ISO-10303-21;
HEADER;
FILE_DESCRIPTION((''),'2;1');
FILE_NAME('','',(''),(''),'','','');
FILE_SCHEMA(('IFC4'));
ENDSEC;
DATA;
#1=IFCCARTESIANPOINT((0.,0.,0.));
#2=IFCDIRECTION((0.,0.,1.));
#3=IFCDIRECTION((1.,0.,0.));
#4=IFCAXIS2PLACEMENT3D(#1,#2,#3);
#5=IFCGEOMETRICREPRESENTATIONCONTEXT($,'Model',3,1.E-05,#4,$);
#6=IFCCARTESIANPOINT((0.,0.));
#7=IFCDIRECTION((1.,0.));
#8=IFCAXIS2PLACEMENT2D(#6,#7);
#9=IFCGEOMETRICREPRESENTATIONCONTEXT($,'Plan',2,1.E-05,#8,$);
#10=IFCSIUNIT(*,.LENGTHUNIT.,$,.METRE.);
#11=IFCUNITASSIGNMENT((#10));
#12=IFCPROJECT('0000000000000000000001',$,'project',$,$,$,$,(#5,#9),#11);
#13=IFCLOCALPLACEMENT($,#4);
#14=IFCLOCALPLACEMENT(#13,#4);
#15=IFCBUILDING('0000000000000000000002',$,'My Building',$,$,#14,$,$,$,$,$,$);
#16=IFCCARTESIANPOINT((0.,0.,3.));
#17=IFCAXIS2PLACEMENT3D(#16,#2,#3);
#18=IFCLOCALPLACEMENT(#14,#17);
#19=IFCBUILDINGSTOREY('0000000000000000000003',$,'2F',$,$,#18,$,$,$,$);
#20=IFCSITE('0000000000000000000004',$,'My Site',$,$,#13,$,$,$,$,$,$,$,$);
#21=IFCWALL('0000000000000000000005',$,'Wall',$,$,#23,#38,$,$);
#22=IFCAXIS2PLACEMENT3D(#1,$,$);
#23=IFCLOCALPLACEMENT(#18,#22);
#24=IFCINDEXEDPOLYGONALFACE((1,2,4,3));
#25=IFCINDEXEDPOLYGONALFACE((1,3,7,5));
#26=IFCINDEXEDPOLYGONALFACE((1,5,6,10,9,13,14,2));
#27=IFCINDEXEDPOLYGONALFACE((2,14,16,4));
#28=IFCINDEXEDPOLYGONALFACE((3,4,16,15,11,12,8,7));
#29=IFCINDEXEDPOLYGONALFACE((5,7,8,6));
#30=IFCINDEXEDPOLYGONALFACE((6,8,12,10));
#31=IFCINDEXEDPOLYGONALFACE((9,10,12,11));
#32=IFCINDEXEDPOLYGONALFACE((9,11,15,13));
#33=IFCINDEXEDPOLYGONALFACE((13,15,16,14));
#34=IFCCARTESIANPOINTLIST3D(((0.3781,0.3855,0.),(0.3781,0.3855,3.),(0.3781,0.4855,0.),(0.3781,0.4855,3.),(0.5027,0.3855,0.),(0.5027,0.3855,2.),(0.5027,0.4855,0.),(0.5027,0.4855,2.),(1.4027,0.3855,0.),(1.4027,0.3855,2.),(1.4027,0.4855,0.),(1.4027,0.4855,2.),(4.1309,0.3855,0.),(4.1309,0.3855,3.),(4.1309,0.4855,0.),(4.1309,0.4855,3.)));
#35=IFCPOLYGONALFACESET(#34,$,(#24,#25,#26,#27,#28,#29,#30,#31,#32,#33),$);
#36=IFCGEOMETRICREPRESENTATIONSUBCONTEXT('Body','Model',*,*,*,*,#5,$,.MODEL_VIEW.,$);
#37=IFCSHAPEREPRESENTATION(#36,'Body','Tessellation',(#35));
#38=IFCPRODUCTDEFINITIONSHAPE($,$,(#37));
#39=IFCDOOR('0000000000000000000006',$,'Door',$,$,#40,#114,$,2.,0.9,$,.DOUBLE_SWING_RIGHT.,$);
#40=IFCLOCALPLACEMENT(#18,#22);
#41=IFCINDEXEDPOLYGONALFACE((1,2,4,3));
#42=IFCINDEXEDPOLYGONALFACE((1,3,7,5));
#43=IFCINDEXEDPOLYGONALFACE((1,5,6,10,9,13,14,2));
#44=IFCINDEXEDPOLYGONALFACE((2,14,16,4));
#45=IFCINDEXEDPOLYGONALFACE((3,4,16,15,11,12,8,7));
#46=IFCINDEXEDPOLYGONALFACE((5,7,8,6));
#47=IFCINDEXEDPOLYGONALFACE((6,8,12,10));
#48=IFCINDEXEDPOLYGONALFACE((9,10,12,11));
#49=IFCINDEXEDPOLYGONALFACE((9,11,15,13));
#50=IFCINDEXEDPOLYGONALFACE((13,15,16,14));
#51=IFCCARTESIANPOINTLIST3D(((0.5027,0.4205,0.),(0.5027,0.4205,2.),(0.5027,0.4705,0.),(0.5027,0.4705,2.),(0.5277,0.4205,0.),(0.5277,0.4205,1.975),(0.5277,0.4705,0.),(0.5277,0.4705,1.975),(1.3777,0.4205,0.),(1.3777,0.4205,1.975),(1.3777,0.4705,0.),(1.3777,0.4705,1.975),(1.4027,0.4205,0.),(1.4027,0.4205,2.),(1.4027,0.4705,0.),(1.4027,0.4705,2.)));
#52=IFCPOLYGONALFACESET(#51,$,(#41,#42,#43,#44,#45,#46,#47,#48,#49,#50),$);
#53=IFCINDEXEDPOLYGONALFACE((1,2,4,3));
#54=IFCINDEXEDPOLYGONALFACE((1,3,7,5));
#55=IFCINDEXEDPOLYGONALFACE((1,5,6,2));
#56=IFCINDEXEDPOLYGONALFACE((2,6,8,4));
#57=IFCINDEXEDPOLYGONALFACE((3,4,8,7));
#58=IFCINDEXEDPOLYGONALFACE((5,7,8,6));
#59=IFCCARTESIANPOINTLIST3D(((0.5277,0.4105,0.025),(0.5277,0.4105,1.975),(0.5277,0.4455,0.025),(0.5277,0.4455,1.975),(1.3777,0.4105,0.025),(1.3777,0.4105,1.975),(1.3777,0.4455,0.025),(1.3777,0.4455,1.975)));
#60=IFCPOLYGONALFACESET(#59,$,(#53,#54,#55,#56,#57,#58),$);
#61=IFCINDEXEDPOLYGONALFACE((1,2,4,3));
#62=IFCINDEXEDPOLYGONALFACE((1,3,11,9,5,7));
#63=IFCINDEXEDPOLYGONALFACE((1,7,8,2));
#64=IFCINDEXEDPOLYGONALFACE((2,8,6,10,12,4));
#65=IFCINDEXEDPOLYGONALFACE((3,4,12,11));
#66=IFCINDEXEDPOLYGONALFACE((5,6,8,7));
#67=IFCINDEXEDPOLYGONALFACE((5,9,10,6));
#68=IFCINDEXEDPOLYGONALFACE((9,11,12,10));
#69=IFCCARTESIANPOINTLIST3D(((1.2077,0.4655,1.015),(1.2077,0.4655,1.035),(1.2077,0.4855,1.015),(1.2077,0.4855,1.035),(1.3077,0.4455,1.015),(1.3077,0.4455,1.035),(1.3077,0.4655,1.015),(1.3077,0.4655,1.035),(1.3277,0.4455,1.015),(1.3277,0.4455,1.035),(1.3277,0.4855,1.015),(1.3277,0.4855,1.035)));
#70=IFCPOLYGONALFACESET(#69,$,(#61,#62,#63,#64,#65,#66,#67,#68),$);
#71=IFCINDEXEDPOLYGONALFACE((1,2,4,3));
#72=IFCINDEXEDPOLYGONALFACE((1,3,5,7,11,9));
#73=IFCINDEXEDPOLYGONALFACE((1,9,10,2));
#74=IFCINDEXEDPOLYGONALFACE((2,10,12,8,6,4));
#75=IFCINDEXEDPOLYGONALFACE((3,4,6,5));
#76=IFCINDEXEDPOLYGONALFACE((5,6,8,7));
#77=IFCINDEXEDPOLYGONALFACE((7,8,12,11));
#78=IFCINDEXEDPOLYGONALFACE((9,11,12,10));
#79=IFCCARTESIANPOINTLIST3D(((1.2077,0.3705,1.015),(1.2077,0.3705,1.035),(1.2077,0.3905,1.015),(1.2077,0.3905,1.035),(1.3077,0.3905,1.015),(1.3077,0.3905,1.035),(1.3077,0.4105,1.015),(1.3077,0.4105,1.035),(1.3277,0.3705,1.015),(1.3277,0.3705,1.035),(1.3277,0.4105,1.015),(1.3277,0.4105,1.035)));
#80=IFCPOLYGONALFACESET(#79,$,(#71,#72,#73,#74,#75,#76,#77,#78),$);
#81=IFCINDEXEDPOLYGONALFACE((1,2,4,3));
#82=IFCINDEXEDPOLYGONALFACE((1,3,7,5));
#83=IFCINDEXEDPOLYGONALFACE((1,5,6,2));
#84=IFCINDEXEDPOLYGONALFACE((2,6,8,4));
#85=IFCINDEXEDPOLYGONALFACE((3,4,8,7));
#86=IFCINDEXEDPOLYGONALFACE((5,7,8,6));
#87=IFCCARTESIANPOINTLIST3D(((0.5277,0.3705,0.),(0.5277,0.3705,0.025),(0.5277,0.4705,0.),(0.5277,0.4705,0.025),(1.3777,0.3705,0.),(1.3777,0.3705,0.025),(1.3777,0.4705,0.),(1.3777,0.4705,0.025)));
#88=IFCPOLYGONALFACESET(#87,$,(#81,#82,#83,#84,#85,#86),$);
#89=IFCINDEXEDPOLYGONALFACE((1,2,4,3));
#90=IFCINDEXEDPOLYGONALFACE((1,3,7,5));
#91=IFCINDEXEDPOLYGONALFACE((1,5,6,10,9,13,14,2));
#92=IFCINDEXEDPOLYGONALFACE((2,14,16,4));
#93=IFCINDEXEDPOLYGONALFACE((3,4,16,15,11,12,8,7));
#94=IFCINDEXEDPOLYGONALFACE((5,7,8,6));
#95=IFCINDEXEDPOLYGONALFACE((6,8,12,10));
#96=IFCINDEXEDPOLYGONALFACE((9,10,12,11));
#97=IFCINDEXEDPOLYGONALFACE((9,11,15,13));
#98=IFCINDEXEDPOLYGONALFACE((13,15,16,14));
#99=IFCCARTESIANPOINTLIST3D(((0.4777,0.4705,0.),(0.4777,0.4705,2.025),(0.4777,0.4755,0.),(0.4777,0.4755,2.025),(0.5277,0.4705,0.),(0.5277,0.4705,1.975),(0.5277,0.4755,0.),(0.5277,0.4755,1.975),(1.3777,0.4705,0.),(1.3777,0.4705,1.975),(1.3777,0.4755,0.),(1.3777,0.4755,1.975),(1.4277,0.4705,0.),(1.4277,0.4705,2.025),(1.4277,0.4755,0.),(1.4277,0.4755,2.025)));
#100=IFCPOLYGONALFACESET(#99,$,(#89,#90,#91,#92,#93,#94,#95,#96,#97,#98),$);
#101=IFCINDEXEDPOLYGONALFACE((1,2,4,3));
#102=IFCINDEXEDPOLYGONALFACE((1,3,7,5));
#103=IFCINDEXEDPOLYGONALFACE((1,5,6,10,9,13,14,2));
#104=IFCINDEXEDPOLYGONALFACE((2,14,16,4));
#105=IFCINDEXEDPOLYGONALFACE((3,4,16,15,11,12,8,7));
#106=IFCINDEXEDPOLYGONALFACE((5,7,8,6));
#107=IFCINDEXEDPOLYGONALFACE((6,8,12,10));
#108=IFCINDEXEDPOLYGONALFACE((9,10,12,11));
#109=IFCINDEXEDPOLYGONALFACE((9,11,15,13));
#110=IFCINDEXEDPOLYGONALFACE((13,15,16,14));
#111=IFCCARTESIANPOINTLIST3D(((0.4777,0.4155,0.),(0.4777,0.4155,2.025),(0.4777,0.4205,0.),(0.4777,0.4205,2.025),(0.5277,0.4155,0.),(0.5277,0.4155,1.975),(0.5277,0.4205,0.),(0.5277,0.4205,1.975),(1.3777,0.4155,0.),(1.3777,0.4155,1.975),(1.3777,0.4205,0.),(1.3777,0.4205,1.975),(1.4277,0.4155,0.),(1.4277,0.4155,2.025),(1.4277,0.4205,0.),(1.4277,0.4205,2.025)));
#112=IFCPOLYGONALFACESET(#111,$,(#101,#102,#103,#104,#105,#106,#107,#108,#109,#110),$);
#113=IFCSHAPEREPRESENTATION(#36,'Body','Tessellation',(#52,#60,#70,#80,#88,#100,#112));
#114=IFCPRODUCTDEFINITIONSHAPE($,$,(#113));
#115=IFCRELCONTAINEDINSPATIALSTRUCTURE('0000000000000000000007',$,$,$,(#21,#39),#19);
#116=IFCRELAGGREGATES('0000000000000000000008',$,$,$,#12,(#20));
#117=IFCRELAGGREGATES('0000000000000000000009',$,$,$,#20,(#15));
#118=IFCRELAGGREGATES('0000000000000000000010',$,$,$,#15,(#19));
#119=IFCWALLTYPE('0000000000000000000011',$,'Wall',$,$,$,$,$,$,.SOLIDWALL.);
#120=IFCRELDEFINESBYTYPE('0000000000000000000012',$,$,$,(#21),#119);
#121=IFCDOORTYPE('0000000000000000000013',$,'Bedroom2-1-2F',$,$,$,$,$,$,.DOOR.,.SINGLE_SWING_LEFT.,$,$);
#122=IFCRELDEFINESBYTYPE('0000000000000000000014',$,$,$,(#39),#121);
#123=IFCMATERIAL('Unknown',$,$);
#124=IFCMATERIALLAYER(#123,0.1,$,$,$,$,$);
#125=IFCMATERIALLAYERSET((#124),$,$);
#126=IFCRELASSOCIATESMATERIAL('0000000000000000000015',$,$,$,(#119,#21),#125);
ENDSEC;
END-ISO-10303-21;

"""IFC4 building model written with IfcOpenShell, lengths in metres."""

from ifc_helpers import new_model, entity, si_unit, frame, origin_with_axes, origin_2d_with_axis, place, context, subcontext, project, spatial, line, indexed_curve, outline, extrude, shape, source, transform, mapped, material, layer, layer_set, layer_usage, type_object, type_shapes, element, fill, save


model = new_model("IFC4")

# Units and contexts
model_context = context("Model", 3, precision=1e-05, world=origin_with_axes())
plan_context = context("Plan", 2, precision=1e-05, world=origin_2d_with_axis())
body_context_1 = subcontext(model_context, "Body", "Model", "MODEL_VIEW")
body_context_2 = subcontext(plan_context, "Body", "Plan", "PLAN_VIEW")
ifc_project = project(units=[si_unit("LENGTHUNIT", "METRE")], contexts=[model_context, plan_context])

# Site, building, storey
site_placement = place(None, origin_with_axes())
site = spatial("IfcSite", under=ifc_project, at=site_placement, Name="My Site")
building_placement = place(site_placement, origin_with_axes())
building = spatial("IfcBuilding", under=site, at=building_placement, Name="My Building")
storey_placement = place(building_placement, frame((0.0, 0.0, 3.0), z_axis=(0.0, 0.0, 1.0), x_axis=(1.0, 0.0, 0.0)))
storey = spatial("IfcBuildingStorey", under=building, at=storey_placement, Name="2F")

# Shared definitions
ifc_material = material(Name="Unknown")
ifc_layer = layer(ifc_material, 0.1)
ifc_layer_set = layer_set([ifc_layer])
wall_type = type_object("IfcWallType", Name="Wall", PredefinedType="SOLIDWALL", material=ifc_layer_set)

# Wall, opening, door
ifc_layer_usage_1 = layer_usage(ifc_layer_set, "AXIS2", "POSITIVE", 0.0)
wall_1_placement = place(storey_placement, frame((0.3781, 0.3855, 0.0), z_axis=(0.0, 0.0, 1.0), x_axis=(1.0, 0.0, 0.0)))
wall_1 = element("IfcWall", 1, at=wall_1_placement, inside=storey, type_object=wall_type, material=ifc_layer_usage_1, Name="Wall", context=body_context_1, shape_type="SweptSolid", body=[
    extrude(outline(indexed_curve([(0.0, 0.0), (0.0, 0.1), (3.7528, 0.1), (3.7528, 0.0)], segments=[line(1, 2, 3, 4, 1)])), origin_with_axes(), (0.0, 0.0, 1.0), 3.0),
])
shared_shape_1 = source(origin_with_axes(), body_context_1, "Body", "SweptSolid", [
    extrude(outline(indexed_curve([(0.0, 0.0), (0.9, 0.0), (0.9, 2.0), (0.0, 2.0)], segments=[line(1, 2, 3, 4, 1)])), frame((0.0, -0.6, 0.0), z_axis=(0.0, -1.0, 0.0), x_axis=(1.0, 0.0, 0.0)), (0.0, 0.0, -1.0), 1.2),
])
opening_1_placement = place(wall_1_placement, frame((1.0245, 0.085, 0.0), z_axis=(0.0, 0.0, 1.0), x_axis=(-1.0, 0.0, 0.0)))
opening_1 = element("IfcOpeningElement", 2, at=opening_1_placement, cuts=wall_1, PredefinedType="OPENING", context=body_context_1, shape_type="MappedRepresentation", body=[
    mapped(shared_shape_1, transform((0.0, 0.0, 0.0), x_axis=(1.0, 0.0, 0.0), y_axis=(0.0, 1.0, 0.0), z_axis=(0.0, 0.0, 1.0), scale=1.0)),
])
door_type_1 = type_object("IfcDoorType", Name="Bedroom2-1-2F", OperationType="SINGLE_SWING_LEFT", PredefinedType="DOOR")
shared_shape_2 = source(origin_with_axes(), body_context_1, "Body", "SweptSolid", [
    extrude(outline(indexed_curve([(0.0, 0.0), (0.0, 2.0), (0.9, 2.0), (0.9, 0.0), (0.875, 0.0), (0.875, 1.975), (0.025, 1.975), (0.025, 0.0)], segments=[line(1, 2, 3, 4, 5, 6, 7, 8, 1)])), frame((0.0, 0.0, 0.0), z_axis=(0.0, -1.0, 0.0), x_axis=(1.0, 0.0, 0.0)), (0.0, 0.0, -1.0), 0.05),
    extrude(outline(indexed_curve([(0.0, 0.0), (0.85, 0.0), (0.85, 0.035), (0.0, 0.035)], segments=[line(1, 2, 3, 4, 1)])), frame((0.025, 0.025, 0.025), z_axis=(0.0, 0.0, 1.0), x_axis=(1.0, 0.0, 0.0)), (0.0, 0.0, 1.0), 1.95),
    extrude(outline(indexed_curve([(0.0, 0.0), (0.0, -0.04), (0.12, -0.04), (0.12, -0.02), (0.02, -0.02), (0.02, 0.0)], segments=[line(1, 2, 3, 4, 5, 6, 1)])), frame((0.075, 0.025, 1.015), z_axis=(0.0, 0.0, 1.0), x_axis=(1.0, 0.0, 0.0)), (0.0, 0.0, 1.0), 0.02),
    extrude(outline(indexed_curve([(0.0, 0.0), (0.0, 0.04), (0.12, 0.04), (0.12, 0.02), (0.02, 0.02), (0.02, 0.0)], segments=[line(1, 2, 3, 4, 5, 6, 1)])), frame((0.075, 0.06, 1.015), z_axis=(0.0, 0.0, 1.0), x_axis=(1.0, 0.0, 0.0)), (0.0, 0.0, 1.0), 0.02),
    extrude(outline(indexed_curve([(0.0, 0.0), (0.85, 0.0), (0.85, 0.1), (0.0, 0.1)], segments=[line(1, 2, 3, 4, 1)])), frame((0.025, 0.0, 0.0), z_axis=(0.0, 0.0, 1.0), x_axis=(1.0, 0.0, 0.0)), (0.0, 0.0, 1.0), 0.025),
    extrude(outline(indexed_curve([(0.0, 0.0), (0.0, 2.025), (0.95, 2.025), (0.95, 0.0), (0.9, 0.0), (0.9, 1.975), (0.05, 1.975), (0.05, 0.0)], segments=[line(1, 2, 3, 4, 5, 6, 7, 8, 1)])), frame((-0.025, -0.005, 0.0), z_axis=(0.0, -1.0, 0.0), x_axis=(1.0, 0.0, 0.0)), (0.0, 0.0, -1.0), 0.005),
    extrude(outline(indexed_curve([(0.0, 0.0), (0.0, 2.025), (0.95, 2.025), (0.95, 0.0), (0.9, 0.0), (0.9, 1.975), (0.05, 1.975), (0.05, 0.0)], segments=[line(1, 2, 3, 4, 5, 6, 7, 8, 1)])), frame((-0.025, 0.05, 0.0), z_axis=(0.0, -1.0, 0.0), x_axis=(1.0, 0.0, 0.0)), (0.0, 0.0, -1.0), 0.005),
])
shared_shape_3 = source(origin_with_axes(), body_context_2, "Body", "Curve2D", [
    entity("IfcIndexedPolyCurve", entity("IfcCartesianPointList2D", [[0.0, 0.0], [0.025, 0.0], [0.025, 0.05], [0.0, 0.05]]), [entity("IfcLineIndex", [1, 2, 3, 4, 1])]),
    entity("IfcIndexedPolyCurve", entity("IfcCartesianPointList2D", [[0.9, 0.0], [0.875, 0.0], [0.875, 0.05], [0.9, 0.05]]), [entity("IfcLineIndex", [1, 2, 3, 4, 1])]),
    entity("IfcIndexedPolyCurve", entity("IfcCartesianPointList2D", [[0.875, 0.05], [0.875, -0.8], [0.84, -0.8]])),
    entity("IfcTrimmedCurve", entity("IfcEllipse", entity("IfcAxis2Placement2D", entity("IfcCartesianPoint", [0.84, 0.05]), entity("IfcDirection", [1.0, 0.0])), 0.815, 0.85), [entity("IfcCartesianPoint", [0.84, 0.9])], [entity("IfcCartesianPoint", [0.84, -0.8])], True, "CARTESIAN"),
    entity("IfcIndexedPolyCurve", entity("IfcCartesianPointList2D", [[0.875, 0.05], [0.84, 0.05], [0.84, 0.9], [0.875, 0.9]]), [entity("IfcLineIndex", [1, 2, 3, 4, 1])]),
])
type_shapes(door_type_1, [shared_shape_2, shared_shape_3])
door_1_placement = place(opening_1_placement, origin_with_axes())
door_1 = element("IfcDoor", 3, at=door_1_placement, inside=storey, type_object=door_type_1, Name="Door", OperationType="DOUBLE_SWING_RIGHT", OverallHeight=2.0, OverallWidth=0.9, shapes=[
    shape(body_context_1, "Body", "MappedRepresentation", [mapped(shared_shape_2, transform((0.0, 0.0, 0.0), x_axis=(1.0, 0.0, 0.0), y_axis=(0.0, 1.0, 0.0), z_axis=(0.0, 0.0, 1.0), scale=1.0))]),
    shape(body_context_2, "Body", "MappedRepresentation", [mapped(shared_shape_3, transform((0.0, 0.0, 0.0), x_axis=(1.0, 0.0, 0.0), y_axis=(0.0, 1.0, 0.0), z_axis=(0.0, 0.0, 1.0), scale=1.0))]),
])
fill(opening_1, door_1)

save(model, "model.ifc")
